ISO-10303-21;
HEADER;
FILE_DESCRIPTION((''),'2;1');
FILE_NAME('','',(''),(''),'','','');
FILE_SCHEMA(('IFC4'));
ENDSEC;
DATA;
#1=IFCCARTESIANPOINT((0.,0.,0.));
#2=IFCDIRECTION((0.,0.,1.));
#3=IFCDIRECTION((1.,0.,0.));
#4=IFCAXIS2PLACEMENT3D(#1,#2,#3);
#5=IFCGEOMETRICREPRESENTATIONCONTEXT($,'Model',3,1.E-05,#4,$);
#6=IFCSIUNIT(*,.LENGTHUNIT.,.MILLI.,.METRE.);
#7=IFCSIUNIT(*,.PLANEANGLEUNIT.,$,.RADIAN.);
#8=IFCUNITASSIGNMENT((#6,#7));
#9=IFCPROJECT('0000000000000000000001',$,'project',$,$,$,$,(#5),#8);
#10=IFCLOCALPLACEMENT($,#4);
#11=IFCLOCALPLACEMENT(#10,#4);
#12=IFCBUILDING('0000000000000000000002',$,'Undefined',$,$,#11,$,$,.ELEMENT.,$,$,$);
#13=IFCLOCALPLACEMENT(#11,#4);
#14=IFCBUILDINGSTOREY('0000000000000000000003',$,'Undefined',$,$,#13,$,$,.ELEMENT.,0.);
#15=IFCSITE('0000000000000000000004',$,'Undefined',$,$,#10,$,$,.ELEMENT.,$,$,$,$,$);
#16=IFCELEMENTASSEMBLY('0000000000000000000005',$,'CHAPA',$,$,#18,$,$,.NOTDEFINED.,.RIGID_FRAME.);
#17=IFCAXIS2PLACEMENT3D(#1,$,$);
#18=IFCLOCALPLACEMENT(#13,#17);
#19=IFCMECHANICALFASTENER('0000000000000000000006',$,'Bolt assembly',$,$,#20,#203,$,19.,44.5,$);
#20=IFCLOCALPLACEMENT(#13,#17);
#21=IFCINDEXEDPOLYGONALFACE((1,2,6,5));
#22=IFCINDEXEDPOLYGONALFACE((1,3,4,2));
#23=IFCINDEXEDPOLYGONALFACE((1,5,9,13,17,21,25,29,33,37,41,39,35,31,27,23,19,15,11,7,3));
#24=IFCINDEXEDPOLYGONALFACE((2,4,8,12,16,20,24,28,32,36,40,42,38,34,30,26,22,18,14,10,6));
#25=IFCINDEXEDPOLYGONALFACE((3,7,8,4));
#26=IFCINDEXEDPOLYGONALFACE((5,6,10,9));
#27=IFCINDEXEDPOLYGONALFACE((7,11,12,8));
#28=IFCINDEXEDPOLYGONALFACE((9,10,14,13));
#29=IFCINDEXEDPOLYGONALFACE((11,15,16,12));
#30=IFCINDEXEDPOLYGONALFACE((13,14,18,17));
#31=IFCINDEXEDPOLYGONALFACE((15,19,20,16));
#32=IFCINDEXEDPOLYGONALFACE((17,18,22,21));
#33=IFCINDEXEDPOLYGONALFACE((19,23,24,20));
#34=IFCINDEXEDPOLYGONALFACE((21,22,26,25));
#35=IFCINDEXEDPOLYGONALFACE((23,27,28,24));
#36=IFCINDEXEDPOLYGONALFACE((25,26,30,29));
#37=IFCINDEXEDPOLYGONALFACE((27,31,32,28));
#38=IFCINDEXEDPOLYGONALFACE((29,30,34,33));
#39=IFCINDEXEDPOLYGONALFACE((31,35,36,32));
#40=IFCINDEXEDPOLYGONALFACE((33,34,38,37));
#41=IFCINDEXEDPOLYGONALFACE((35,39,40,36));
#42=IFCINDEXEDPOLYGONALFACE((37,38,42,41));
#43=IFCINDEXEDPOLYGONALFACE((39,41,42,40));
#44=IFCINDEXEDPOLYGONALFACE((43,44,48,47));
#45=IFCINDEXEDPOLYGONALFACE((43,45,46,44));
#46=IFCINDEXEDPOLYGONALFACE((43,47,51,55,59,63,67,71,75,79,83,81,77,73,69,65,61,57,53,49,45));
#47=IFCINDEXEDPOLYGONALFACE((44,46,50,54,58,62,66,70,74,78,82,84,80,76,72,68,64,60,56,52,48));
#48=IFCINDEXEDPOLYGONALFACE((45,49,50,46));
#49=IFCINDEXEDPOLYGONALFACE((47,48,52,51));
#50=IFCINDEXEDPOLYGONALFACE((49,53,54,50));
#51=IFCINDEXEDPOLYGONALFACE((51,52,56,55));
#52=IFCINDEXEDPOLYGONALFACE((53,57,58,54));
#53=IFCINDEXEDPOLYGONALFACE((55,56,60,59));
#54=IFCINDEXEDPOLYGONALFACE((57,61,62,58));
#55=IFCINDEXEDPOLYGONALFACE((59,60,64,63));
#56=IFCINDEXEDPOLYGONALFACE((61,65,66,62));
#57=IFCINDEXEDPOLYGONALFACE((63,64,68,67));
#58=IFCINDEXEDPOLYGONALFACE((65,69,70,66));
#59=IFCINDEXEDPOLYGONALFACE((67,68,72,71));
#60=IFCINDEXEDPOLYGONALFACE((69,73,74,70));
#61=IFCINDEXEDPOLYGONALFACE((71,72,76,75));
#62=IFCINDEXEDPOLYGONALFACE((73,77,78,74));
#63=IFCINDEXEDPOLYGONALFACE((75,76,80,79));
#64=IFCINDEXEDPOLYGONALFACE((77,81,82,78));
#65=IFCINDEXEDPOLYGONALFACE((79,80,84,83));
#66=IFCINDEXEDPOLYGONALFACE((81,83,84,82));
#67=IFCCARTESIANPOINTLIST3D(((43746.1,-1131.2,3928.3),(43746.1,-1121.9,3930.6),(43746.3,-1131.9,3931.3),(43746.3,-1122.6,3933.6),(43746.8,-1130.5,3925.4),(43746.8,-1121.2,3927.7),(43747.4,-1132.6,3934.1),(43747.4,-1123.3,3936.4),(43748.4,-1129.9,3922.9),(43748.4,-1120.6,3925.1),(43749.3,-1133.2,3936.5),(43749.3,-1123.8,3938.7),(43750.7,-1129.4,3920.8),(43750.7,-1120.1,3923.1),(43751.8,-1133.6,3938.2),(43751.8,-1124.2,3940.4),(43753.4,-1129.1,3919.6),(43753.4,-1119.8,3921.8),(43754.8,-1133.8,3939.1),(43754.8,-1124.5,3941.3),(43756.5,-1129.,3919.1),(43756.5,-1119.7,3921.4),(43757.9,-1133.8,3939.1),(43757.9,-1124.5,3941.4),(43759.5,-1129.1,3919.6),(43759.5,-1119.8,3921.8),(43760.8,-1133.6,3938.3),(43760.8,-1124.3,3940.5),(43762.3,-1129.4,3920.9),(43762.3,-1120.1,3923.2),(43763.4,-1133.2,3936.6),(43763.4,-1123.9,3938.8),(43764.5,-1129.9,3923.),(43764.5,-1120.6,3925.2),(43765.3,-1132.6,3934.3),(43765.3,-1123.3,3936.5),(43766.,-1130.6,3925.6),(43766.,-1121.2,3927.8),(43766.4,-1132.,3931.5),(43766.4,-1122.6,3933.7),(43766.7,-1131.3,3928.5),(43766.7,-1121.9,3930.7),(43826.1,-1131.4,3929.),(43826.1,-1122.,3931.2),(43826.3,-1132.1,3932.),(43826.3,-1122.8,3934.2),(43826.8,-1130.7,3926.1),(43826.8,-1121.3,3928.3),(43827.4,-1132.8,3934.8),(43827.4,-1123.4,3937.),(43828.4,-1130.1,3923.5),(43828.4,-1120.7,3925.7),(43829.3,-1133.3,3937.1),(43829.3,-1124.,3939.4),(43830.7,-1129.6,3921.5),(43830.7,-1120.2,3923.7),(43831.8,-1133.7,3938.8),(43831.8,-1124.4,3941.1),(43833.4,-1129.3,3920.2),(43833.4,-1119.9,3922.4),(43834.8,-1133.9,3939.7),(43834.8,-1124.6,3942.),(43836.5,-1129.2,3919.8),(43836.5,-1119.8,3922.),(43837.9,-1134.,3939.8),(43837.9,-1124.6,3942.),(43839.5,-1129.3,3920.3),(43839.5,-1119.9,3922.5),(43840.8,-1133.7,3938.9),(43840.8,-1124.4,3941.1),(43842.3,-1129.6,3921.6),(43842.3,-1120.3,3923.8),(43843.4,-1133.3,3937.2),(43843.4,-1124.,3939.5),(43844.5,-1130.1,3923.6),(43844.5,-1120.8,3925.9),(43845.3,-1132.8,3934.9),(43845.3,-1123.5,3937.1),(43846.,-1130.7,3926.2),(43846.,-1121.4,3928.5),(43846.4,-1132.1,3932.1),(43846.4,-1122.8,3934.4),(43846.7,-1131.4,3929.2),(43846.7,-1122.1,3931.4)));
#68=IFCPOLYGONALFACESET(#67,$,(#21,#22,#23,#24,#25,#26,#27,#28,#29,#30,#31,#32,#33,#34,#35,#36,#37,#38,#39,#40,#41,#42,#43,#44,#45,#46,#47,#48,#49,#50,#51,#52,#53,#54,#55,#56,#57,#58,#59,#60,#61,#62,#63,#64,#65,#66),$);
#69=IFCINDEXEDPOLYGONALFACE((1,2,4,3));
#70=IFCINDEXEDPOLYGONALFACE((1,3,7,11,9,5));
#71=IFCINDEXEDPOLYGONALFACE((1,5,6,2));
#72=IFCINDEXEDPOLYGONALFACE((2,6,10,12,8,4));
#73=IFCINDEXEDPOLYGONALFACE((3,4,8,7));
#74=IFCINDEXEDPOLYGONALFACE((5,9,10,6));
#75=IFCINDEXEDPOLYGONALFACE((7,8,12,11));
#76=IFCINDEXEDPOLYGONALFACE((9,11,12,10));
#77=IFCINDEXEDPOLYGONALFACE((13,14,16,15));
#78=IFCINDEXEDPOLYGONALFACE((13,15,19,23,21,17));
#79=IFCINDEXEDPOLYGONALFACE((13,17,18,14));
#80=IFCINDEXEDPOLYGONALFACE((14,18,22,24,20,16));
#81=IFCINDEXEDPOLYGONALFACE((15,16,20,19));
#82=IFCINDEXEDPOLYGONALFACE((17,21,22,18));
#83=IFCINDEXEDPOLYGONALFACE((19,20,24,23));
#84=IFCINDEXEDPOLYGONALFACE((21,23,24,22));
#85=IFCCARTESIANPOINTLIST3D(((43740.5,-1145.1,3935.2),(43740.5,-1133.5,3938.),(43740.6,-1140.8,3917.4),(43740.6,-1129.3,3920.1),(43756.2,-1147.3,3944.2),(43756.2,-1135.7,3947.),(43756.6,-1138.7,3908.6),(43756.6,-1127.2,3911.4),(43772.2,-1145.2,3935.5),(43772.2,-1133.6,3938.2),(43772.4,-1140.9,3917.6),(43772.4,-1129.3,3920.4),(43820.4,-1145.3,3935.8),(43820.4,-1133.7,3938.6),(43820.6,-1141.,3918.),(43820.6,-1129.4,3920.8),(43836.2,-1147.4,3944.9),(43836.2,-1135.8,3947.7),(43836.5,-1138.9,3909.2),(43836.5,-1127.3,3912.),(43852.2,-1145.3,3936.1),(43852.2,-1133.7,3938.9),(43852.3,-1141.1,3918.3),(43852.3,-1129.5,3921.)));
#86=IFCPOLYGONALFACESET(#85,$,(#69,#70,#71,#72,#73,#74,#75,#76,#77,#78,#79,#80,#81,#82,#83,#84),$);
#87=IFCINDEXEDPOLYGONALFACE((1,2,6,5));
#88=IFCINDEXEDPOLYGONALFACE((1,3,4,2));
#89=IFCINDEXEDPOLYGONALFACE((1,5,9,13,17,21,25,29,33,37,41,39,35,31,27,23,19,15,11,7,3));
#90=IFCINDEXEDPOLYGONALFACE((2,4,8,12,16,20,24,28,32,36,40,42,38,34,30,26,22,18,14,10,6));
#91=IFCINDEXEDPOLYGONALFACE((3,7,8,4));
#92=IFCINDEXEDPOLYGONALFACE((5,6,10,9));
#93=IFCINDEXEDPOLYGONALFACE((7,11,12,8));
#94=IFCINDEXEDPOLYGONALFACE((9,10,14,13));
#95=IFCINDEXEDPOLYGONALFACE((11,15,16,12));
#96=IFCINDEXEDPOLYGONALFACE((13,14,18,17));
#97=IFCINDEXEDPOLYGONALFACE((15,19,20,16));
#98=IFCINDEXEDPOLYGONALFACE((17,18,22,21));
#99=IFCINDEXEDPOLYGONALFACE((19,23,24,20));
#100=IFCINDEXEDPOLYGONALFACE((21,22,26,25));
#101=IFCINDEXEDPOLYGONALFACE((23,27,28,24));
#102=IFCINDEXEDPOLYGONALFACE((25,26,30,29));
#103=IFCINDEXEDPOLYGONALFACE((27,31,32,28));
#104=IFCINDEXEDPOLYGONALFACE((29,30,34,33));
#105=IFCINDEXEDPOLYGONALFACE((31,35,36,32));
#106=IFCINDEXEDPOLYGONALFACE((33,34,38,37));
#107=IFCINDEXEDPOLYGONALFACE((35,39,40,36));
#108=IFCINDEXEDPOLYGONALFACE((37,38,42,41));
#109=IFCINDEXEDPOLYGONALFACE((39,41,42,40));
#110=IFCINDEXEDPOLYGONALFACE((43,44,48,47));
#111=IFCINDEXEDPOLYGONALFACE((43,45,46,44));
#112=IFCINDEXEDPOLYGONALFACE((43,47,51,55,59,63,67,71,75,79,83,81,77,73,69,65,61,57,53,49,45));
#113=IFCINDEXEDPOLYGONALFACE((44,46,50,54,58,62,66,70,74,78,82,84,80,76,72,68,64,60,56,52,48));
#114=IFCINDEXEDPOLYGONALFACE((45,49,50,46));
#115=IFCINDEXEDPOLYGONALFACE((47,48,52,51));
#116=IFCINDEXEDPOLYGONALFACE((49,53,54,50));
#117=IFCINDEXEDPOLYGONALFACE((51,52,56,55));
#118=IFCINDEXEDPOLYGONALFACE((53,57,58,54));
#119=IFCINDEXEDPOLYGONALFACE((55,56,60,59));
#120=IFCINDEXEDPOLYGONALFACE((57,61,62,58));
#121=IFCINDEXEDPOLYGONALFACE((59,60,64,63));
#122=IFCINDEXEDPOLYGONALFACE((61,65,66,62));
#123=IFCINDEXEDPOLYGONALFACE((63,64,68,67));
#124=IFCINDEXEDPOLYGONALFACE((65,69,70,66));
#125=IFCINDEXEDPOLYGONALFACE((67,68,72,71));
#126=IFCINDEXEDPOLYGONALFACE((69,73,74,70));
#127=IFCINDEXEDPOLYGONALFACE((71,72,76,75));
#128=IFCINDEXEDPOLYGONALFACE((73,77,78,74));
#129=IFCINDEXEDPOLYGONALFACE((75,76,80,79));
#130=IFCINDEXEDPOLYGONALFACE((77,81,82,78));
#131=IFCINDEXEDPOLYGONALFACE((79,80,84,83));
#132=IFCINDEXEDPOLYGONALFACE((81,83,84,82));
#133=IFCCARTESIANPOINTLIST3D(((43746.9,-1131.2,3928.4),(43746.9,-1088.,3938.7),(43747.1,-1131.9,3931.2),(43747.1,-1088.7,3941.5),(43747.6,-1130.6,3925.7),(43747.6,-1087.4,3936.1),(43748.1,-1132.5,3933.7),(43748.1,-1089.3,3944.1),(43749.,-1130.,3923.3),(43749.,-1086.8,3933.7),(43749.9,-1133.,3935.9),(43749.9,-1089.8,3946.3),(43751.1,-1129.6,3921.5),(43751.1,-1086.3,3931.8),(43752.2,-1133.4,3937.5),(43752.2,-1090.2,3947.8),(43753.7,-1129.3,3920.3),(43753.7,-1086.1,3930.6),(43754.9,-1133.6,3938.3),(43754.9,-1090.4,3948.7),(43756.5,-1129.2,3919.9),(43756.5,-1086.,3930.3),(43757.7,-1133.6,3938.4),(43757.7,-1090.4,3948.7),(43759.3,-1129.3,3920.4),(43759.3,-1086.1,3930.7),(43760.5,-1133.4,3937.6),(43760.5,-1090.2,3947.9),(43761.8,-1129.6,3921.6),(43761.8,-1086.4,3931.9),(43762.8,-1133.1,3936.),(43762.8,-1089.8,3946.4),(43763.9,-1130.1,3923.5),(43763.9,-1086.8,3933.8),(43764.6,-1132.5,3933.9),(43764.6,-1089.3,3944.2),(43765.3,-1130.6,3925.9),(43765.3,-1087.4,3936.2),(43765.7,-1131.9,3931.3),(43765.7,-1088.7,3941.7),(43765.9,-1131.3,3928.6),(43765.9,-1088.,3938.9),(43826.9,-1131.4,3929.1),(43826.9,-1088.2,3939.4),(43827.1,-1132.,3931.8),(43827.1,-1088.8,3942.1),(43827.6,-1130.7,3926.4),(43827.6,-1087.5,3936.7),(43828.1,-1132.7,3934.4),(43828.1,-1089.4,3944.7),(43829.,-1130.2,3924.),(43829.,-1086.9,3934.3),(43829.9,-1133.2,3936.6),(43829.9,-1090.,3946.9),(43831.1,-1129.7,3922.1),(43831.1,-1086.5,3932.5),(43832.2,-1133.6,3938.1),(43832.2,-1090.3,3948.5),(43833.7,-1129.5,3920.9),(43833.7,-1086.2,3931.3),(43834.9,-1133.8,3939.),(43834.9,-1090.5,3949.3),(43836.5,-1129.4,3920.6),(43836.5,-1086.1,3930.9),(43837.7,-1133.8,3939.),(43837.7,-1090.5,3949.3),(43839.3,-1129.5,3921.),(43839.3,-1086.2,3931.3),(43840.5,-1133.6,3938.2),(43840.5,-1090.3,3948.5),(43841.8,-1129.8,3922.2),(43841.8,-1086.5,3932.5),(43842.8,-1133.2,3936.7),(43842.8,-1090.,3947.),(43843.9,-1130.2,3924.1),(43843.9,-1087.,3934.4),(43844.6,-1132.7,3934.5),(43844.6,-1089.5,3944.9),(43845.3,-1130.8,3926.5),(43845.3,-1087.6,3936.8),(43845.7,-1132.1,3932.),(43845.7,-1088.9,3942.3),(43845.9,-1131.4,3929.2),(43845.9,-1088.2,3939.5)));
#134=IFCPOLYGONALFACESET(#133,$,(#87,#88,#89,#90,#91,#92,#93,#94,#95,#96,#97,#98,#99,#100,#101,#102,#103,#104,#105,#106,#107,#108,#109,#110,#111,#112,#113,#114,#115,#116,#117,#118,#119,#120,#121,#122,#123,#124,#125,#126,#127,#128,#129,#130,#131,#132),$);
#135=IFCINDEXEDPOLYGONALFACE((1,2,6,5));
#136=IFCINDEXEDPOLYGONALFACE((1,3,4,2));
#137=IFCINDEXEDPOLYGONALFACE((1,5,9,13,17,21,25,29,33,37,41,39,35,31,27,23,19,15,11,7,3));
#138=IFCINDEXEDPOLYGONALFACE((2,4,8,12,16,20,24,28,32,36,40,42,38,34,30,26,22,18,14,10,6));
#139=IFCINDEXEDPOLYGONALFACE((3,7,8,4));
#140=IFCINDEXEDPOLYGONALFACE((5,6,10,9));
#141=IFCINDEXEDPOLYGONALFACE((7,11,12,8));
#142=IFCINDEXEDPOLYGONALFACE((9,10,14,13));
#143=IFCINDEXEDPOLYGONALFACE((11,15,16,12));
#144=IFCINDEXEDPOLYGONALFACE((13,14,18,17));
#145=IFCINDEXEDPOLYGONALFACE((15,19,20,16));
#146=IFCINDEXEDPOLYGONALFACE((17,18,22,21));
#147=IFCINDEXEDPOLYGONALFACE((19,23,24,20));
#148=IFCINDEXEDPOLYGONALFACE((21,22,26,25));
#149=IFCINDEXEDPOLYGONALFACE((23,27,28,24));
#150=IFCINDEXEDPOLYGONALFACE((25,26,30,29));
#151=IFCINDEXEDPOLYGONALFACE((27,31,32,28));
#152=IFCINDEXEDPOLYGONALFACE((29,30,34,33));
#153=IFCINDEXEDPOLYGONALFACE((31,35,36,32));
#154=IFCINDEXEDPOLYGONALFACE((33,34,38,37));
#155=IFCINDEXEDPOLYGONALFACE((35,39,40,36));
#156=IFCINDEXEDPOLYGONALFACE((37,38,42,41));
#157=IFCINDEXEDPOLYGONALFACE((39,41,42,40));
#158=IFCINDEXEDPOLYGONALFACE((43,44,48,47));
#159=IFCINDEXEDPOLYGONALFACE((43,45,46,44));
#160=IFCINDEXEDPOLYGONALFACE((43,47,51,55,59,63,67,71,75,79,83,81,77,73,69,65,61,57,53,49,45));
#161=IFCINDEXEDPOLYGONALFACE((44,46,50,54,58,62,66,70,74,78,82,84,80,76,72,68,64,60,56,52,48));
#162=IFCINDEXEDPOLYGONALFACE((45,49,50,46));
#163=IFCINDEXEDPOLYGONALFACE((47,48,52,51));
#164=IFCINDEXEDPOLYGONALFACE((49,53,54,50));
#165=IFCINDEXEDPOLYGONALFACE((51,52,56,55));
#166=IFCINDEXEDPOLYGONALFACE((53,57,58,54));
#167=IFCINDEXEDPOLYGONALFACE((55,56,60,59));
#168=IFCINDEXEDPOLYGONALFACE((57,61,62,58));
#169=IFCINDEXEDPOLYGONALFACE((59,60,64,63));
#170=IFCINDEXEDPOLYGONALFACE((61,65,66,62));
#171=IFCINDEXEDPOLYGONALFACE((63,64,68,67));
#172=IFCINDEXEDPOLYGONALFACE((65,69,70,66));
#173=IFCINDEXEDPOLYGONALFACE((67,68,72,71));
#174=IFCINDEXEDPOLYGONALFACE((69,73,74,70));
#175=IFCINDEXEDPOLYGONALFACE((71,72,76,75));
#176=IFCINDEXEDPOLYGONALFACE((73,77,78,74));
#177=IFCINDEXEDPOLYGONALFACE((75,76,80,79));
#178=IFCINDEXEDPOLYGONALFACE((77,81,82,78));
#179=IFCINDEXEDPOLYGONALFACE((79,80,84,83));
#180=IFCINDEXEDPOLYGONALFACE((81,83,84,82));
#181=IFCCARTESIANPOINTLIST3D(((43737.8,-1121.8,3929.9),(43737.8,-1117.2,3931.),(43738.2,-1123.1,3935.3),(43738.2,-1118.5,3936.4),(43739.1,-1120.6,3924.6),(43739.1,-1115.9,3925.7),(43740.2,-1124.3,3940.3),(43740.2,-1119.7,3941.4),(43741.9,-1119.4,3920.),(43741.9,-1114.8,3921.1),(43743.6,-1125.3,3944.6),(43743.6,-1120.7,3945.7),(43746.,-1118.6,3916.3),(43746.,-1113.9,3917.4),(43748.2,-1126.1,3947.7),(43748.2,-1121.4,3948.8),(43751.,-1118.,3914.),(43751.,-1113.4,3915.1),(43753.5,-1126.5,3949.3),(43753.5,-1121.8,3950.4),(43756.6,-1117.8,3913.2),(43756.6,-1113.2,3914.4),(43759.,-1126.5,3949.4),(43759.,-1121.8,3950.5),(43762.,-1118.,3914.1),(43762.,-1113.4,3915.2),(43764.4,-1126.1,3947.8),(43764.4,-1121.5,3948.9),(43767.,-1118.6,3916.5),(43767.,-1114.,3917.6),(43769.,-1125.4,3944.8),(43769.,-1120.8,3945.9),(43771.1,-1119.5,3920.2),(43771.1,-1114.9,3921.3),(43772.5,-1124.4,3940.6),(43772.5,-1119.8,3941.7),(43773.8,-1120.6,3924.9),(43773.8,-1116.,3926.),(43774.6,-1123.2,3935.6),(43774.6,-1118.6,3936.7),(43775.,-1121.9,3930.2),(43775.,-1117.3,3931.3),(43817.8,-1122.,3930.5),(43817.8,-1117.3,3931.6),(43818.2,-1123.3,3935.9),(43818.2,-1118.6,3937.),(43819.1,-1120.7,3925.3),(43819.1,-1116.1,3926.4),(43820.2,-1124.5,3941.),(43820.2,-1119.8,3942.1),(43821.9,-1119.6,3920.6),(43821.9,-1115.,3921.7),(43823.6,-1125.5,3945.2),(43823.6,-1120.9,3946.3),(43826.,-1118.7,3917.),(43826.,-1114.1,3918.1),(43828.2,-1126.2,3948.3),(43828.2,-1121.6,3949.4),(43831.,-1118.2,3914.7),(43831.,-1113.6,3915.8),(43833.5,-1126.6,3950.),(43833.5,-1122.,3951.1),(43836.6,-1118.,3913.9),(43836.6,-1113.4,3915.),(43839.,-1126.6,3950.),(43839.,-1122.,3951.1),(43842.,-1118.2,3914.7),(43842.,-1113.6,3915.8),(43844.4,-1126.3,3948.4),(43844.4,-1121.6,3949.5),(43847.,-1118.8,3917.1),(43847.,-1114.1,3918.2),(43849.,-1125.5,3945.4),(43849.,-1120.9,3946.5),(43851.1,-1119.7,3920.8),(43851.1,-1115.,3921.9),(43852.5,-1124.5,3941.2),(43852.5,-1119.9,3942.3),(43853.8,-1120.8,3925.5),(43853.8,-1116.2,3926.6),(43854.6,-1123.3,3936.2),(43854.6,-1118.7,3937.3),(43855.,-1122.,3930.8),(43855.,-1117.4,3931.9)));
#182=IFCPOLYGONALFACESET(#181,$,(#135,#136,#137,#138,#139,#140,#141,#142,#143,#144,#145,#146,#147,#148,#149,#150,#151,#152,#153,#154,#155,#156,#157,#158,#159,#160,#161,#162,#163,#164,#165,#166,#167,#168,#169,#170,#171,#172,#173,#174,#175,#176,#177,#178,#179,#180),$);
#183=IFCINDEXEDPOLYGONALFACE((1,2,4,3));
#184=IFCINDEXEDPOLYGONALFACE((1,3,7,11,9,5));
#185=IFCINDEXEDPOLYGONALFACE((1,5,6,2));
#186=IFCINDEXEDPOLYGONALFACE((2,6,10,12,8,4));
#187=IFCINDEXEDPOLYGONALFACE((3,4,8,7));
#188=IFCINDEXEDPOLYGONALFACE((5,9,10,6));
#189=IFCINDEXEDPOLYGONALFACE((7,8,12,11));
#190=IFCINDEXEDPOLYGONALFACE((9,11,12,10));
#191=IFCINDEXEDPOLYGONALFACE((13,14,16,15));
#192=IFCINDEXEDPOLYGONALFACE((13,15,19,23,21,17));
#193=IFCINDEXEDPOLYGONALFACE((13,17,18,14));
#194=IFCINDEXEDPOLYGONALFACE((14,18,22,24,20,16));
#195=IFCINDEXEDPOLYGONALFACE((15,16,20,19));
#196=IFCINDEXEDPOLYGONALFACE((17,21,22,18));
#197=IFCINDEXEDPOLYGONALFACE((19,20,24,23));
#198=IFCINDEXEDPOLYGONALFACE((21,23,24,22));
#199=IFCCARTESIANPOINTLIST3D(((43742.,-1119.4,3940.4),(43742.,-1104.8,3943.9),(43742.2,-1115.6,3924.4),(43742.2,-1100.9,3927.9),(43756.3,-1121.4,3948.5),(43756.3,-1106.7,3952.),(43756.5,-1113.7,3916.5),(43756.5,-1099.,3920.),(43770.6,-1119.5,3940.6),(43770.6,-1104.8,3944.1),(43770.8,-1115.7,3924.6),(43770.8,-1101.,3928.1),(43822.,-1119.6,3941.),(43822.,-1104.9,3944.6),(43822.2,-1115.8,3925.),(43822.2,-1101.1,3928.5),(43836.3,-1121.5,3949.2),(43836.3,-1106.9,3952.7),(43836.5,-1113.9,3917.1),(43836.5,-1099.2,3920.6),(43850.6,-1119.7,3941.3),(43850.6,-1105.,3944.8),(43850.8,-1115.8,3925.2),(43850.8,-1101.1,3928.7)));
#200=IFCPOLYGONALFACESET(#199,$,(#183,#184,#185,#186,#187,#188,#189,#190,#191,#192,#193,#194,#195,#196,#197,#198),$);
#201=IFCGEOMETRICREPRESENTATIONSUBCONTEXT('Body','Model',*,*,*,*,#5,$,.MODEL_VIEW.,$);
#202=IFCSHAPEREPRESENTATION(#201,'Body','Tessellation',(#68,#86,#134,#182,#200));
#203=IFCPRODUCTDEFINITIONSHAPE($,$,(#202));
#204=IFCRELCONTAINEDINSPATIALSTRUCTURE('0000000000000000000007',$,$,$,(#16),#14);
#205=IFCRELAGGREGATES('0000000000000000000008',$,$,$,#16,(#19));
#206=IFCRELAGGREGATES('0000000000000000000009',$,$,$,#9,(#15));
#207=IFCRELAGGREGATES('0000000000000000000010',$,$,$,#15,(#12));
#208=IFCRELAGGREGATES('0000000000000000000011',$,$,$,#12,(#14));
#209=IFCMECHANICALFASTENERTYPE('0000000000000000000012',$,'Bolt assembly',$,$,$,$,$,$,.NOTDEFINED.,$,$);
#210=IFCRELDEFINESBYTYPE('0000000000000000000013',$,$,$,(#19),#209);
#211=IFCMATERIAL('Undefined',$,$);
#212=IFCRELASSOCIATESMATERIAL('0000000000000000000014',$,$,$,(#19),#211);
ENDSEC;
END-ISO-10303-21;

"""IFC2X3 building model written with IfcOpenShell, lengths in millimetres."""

from ifc_helpers import new_model, si_unit, frame, origin_with_axes, origin_2d_with_axis, place, context, subcontext, project, spatial, polyline, circle, outline, extrude, source, transform, mapped, material, type_object, element, aggregate, save


model = new_model("IFC2X3")

# Units and contexts
model_context = context("Model", 3, precision=1e-05, world=origin_with_axes())
body_context = subcontext(model_context, "Body", "Model", "MODEL_VIEW")
ifc_project = project(units=[si_unit("LENGTHUNIT", "METRE", prefix="MILLI"), si_unit("PLANEANGLEUNIT", "RADIAN")], contexts=[model_context])

# Site, building, storey
site_placement = place(None, origin_with_axes())
site = spatial("IfcSite", under=ifc_project, at=site_placement, Name="Undefined", CompositionType="ELEMENT")
building_placement = place(site_placement, origin_with_axes())
building = spatial("IfcBuilding", under=site, at=building_placement, Name="Undefined", CompositionType="ELEMENT")
storey_placement = place(building_placement, origin_with_axes())
storey = spatial("IfcBuildingStorey", under=building, at=storey_placement, Name="Undefined", CompositionType="ELEMENT", Elevation=0.0)

# Element assembly
assembly_1_placement = place(storey_placement, origin_with_axes())
assembly_1 = element("IfcElementAssembly", 1, at=assembly_1_placement, inside=storey, Name="CHAPA", AssemblyPlace="NOTDEFINED", PredefinedType="RIGID_FRAME")

# Shared definitions
ifc_material_1 = material(Name="Undefined")
mechanical_fastener_type = type_object("IfcMechanicalFastenerType", Name="Bolt assembly")

# Mechanical fastener
shared_shape_1 = source(origin_with_axes(), body_context, "Body", "SweptSolid", [
    extrude(circle(Radius=10.3, at=origin_2d_with_axis()), frame((0.0, 0.0, 0.0), z_axis=(0.0, 1.0, 0.0), x_axis=(1.0, 0.0, 0.0)), (0.0, 0.0, 1.0), 9.6),
    extrude(outline(polyline([(18.3, 0.0), (9.2, 15.9), (-9.2, 15.9), (-18.3, 0.0), (-9.2, -15.9), (9.2, -15.9), (18.3, 0.0)])), frame((0.0, -11.9, 0.0), z_axis=(0.0, 1.0, 0.0), x_axis=(1.0, 0.0, 0.0)), (0.0, 0.0, 1.0), 11.9),
    extrude(circle(Radius=9.5, at=origin_2d_with_axis()), frame((0.0, 0.0, 0.0), z_axis=(0.0, 1.0, 0.0), x_axis=(1.0, 0.0, 0.0)), (0.0, 0.0, 1.0), 44.5),
    extrude(circle(Radius=18.7, at=origin_2d_with_axis()), frame((0.0, 9.5, 0.0), z_axis=(0.0, 1.0, 0.0), x_axis=(1.0, 0.0, 0.0)), (0.0, 0.0, 1.0), 4.8),
    extrude(outline(polyline([(16.5, 0.0), (8.2, 14.3), (-8.2, 14.3), (-16.5, 0.0), (-8.2, -14.3), (8.2, -14.3), (16.5, 0.0)])), frame((0.0, 14.3, 0.0), z_axis=(0.0, 1.0, 0.0), x_axis=(1.0, 0.0, 0.0)), (0.0, 0.0, 1.0), 15.1),
])
mechanical_fastener_1_placement = place(assembly_1_placement, frame((43796.4, -1131.5, 3929.5), z_axis=(0.999966, -0.001918, 0.008027), x_axis=(0.008253, 0.23249, -0.972564)))
mechanical_fastener_1 = element("IfcMechanicalFastener", 2, at=mechanical_fastener_1_placement, type_object=mechanical_fastener_type, material=ifc_material_1, Name="Bolt assembly", NominalDiameter=19.0, NominalLength=44.5, context=body_context, shape_type="MappedRepresentation", body=[
    mapped(shared_shape_1, transform((0.0, 0.0, -40.0))),
    mapped(shared_shape_1, transform((0.0, 0.0, 40.0))),
])
aggregate(assembly_1, [mechanical_fastener_1])

save(model, "model.ifc")
